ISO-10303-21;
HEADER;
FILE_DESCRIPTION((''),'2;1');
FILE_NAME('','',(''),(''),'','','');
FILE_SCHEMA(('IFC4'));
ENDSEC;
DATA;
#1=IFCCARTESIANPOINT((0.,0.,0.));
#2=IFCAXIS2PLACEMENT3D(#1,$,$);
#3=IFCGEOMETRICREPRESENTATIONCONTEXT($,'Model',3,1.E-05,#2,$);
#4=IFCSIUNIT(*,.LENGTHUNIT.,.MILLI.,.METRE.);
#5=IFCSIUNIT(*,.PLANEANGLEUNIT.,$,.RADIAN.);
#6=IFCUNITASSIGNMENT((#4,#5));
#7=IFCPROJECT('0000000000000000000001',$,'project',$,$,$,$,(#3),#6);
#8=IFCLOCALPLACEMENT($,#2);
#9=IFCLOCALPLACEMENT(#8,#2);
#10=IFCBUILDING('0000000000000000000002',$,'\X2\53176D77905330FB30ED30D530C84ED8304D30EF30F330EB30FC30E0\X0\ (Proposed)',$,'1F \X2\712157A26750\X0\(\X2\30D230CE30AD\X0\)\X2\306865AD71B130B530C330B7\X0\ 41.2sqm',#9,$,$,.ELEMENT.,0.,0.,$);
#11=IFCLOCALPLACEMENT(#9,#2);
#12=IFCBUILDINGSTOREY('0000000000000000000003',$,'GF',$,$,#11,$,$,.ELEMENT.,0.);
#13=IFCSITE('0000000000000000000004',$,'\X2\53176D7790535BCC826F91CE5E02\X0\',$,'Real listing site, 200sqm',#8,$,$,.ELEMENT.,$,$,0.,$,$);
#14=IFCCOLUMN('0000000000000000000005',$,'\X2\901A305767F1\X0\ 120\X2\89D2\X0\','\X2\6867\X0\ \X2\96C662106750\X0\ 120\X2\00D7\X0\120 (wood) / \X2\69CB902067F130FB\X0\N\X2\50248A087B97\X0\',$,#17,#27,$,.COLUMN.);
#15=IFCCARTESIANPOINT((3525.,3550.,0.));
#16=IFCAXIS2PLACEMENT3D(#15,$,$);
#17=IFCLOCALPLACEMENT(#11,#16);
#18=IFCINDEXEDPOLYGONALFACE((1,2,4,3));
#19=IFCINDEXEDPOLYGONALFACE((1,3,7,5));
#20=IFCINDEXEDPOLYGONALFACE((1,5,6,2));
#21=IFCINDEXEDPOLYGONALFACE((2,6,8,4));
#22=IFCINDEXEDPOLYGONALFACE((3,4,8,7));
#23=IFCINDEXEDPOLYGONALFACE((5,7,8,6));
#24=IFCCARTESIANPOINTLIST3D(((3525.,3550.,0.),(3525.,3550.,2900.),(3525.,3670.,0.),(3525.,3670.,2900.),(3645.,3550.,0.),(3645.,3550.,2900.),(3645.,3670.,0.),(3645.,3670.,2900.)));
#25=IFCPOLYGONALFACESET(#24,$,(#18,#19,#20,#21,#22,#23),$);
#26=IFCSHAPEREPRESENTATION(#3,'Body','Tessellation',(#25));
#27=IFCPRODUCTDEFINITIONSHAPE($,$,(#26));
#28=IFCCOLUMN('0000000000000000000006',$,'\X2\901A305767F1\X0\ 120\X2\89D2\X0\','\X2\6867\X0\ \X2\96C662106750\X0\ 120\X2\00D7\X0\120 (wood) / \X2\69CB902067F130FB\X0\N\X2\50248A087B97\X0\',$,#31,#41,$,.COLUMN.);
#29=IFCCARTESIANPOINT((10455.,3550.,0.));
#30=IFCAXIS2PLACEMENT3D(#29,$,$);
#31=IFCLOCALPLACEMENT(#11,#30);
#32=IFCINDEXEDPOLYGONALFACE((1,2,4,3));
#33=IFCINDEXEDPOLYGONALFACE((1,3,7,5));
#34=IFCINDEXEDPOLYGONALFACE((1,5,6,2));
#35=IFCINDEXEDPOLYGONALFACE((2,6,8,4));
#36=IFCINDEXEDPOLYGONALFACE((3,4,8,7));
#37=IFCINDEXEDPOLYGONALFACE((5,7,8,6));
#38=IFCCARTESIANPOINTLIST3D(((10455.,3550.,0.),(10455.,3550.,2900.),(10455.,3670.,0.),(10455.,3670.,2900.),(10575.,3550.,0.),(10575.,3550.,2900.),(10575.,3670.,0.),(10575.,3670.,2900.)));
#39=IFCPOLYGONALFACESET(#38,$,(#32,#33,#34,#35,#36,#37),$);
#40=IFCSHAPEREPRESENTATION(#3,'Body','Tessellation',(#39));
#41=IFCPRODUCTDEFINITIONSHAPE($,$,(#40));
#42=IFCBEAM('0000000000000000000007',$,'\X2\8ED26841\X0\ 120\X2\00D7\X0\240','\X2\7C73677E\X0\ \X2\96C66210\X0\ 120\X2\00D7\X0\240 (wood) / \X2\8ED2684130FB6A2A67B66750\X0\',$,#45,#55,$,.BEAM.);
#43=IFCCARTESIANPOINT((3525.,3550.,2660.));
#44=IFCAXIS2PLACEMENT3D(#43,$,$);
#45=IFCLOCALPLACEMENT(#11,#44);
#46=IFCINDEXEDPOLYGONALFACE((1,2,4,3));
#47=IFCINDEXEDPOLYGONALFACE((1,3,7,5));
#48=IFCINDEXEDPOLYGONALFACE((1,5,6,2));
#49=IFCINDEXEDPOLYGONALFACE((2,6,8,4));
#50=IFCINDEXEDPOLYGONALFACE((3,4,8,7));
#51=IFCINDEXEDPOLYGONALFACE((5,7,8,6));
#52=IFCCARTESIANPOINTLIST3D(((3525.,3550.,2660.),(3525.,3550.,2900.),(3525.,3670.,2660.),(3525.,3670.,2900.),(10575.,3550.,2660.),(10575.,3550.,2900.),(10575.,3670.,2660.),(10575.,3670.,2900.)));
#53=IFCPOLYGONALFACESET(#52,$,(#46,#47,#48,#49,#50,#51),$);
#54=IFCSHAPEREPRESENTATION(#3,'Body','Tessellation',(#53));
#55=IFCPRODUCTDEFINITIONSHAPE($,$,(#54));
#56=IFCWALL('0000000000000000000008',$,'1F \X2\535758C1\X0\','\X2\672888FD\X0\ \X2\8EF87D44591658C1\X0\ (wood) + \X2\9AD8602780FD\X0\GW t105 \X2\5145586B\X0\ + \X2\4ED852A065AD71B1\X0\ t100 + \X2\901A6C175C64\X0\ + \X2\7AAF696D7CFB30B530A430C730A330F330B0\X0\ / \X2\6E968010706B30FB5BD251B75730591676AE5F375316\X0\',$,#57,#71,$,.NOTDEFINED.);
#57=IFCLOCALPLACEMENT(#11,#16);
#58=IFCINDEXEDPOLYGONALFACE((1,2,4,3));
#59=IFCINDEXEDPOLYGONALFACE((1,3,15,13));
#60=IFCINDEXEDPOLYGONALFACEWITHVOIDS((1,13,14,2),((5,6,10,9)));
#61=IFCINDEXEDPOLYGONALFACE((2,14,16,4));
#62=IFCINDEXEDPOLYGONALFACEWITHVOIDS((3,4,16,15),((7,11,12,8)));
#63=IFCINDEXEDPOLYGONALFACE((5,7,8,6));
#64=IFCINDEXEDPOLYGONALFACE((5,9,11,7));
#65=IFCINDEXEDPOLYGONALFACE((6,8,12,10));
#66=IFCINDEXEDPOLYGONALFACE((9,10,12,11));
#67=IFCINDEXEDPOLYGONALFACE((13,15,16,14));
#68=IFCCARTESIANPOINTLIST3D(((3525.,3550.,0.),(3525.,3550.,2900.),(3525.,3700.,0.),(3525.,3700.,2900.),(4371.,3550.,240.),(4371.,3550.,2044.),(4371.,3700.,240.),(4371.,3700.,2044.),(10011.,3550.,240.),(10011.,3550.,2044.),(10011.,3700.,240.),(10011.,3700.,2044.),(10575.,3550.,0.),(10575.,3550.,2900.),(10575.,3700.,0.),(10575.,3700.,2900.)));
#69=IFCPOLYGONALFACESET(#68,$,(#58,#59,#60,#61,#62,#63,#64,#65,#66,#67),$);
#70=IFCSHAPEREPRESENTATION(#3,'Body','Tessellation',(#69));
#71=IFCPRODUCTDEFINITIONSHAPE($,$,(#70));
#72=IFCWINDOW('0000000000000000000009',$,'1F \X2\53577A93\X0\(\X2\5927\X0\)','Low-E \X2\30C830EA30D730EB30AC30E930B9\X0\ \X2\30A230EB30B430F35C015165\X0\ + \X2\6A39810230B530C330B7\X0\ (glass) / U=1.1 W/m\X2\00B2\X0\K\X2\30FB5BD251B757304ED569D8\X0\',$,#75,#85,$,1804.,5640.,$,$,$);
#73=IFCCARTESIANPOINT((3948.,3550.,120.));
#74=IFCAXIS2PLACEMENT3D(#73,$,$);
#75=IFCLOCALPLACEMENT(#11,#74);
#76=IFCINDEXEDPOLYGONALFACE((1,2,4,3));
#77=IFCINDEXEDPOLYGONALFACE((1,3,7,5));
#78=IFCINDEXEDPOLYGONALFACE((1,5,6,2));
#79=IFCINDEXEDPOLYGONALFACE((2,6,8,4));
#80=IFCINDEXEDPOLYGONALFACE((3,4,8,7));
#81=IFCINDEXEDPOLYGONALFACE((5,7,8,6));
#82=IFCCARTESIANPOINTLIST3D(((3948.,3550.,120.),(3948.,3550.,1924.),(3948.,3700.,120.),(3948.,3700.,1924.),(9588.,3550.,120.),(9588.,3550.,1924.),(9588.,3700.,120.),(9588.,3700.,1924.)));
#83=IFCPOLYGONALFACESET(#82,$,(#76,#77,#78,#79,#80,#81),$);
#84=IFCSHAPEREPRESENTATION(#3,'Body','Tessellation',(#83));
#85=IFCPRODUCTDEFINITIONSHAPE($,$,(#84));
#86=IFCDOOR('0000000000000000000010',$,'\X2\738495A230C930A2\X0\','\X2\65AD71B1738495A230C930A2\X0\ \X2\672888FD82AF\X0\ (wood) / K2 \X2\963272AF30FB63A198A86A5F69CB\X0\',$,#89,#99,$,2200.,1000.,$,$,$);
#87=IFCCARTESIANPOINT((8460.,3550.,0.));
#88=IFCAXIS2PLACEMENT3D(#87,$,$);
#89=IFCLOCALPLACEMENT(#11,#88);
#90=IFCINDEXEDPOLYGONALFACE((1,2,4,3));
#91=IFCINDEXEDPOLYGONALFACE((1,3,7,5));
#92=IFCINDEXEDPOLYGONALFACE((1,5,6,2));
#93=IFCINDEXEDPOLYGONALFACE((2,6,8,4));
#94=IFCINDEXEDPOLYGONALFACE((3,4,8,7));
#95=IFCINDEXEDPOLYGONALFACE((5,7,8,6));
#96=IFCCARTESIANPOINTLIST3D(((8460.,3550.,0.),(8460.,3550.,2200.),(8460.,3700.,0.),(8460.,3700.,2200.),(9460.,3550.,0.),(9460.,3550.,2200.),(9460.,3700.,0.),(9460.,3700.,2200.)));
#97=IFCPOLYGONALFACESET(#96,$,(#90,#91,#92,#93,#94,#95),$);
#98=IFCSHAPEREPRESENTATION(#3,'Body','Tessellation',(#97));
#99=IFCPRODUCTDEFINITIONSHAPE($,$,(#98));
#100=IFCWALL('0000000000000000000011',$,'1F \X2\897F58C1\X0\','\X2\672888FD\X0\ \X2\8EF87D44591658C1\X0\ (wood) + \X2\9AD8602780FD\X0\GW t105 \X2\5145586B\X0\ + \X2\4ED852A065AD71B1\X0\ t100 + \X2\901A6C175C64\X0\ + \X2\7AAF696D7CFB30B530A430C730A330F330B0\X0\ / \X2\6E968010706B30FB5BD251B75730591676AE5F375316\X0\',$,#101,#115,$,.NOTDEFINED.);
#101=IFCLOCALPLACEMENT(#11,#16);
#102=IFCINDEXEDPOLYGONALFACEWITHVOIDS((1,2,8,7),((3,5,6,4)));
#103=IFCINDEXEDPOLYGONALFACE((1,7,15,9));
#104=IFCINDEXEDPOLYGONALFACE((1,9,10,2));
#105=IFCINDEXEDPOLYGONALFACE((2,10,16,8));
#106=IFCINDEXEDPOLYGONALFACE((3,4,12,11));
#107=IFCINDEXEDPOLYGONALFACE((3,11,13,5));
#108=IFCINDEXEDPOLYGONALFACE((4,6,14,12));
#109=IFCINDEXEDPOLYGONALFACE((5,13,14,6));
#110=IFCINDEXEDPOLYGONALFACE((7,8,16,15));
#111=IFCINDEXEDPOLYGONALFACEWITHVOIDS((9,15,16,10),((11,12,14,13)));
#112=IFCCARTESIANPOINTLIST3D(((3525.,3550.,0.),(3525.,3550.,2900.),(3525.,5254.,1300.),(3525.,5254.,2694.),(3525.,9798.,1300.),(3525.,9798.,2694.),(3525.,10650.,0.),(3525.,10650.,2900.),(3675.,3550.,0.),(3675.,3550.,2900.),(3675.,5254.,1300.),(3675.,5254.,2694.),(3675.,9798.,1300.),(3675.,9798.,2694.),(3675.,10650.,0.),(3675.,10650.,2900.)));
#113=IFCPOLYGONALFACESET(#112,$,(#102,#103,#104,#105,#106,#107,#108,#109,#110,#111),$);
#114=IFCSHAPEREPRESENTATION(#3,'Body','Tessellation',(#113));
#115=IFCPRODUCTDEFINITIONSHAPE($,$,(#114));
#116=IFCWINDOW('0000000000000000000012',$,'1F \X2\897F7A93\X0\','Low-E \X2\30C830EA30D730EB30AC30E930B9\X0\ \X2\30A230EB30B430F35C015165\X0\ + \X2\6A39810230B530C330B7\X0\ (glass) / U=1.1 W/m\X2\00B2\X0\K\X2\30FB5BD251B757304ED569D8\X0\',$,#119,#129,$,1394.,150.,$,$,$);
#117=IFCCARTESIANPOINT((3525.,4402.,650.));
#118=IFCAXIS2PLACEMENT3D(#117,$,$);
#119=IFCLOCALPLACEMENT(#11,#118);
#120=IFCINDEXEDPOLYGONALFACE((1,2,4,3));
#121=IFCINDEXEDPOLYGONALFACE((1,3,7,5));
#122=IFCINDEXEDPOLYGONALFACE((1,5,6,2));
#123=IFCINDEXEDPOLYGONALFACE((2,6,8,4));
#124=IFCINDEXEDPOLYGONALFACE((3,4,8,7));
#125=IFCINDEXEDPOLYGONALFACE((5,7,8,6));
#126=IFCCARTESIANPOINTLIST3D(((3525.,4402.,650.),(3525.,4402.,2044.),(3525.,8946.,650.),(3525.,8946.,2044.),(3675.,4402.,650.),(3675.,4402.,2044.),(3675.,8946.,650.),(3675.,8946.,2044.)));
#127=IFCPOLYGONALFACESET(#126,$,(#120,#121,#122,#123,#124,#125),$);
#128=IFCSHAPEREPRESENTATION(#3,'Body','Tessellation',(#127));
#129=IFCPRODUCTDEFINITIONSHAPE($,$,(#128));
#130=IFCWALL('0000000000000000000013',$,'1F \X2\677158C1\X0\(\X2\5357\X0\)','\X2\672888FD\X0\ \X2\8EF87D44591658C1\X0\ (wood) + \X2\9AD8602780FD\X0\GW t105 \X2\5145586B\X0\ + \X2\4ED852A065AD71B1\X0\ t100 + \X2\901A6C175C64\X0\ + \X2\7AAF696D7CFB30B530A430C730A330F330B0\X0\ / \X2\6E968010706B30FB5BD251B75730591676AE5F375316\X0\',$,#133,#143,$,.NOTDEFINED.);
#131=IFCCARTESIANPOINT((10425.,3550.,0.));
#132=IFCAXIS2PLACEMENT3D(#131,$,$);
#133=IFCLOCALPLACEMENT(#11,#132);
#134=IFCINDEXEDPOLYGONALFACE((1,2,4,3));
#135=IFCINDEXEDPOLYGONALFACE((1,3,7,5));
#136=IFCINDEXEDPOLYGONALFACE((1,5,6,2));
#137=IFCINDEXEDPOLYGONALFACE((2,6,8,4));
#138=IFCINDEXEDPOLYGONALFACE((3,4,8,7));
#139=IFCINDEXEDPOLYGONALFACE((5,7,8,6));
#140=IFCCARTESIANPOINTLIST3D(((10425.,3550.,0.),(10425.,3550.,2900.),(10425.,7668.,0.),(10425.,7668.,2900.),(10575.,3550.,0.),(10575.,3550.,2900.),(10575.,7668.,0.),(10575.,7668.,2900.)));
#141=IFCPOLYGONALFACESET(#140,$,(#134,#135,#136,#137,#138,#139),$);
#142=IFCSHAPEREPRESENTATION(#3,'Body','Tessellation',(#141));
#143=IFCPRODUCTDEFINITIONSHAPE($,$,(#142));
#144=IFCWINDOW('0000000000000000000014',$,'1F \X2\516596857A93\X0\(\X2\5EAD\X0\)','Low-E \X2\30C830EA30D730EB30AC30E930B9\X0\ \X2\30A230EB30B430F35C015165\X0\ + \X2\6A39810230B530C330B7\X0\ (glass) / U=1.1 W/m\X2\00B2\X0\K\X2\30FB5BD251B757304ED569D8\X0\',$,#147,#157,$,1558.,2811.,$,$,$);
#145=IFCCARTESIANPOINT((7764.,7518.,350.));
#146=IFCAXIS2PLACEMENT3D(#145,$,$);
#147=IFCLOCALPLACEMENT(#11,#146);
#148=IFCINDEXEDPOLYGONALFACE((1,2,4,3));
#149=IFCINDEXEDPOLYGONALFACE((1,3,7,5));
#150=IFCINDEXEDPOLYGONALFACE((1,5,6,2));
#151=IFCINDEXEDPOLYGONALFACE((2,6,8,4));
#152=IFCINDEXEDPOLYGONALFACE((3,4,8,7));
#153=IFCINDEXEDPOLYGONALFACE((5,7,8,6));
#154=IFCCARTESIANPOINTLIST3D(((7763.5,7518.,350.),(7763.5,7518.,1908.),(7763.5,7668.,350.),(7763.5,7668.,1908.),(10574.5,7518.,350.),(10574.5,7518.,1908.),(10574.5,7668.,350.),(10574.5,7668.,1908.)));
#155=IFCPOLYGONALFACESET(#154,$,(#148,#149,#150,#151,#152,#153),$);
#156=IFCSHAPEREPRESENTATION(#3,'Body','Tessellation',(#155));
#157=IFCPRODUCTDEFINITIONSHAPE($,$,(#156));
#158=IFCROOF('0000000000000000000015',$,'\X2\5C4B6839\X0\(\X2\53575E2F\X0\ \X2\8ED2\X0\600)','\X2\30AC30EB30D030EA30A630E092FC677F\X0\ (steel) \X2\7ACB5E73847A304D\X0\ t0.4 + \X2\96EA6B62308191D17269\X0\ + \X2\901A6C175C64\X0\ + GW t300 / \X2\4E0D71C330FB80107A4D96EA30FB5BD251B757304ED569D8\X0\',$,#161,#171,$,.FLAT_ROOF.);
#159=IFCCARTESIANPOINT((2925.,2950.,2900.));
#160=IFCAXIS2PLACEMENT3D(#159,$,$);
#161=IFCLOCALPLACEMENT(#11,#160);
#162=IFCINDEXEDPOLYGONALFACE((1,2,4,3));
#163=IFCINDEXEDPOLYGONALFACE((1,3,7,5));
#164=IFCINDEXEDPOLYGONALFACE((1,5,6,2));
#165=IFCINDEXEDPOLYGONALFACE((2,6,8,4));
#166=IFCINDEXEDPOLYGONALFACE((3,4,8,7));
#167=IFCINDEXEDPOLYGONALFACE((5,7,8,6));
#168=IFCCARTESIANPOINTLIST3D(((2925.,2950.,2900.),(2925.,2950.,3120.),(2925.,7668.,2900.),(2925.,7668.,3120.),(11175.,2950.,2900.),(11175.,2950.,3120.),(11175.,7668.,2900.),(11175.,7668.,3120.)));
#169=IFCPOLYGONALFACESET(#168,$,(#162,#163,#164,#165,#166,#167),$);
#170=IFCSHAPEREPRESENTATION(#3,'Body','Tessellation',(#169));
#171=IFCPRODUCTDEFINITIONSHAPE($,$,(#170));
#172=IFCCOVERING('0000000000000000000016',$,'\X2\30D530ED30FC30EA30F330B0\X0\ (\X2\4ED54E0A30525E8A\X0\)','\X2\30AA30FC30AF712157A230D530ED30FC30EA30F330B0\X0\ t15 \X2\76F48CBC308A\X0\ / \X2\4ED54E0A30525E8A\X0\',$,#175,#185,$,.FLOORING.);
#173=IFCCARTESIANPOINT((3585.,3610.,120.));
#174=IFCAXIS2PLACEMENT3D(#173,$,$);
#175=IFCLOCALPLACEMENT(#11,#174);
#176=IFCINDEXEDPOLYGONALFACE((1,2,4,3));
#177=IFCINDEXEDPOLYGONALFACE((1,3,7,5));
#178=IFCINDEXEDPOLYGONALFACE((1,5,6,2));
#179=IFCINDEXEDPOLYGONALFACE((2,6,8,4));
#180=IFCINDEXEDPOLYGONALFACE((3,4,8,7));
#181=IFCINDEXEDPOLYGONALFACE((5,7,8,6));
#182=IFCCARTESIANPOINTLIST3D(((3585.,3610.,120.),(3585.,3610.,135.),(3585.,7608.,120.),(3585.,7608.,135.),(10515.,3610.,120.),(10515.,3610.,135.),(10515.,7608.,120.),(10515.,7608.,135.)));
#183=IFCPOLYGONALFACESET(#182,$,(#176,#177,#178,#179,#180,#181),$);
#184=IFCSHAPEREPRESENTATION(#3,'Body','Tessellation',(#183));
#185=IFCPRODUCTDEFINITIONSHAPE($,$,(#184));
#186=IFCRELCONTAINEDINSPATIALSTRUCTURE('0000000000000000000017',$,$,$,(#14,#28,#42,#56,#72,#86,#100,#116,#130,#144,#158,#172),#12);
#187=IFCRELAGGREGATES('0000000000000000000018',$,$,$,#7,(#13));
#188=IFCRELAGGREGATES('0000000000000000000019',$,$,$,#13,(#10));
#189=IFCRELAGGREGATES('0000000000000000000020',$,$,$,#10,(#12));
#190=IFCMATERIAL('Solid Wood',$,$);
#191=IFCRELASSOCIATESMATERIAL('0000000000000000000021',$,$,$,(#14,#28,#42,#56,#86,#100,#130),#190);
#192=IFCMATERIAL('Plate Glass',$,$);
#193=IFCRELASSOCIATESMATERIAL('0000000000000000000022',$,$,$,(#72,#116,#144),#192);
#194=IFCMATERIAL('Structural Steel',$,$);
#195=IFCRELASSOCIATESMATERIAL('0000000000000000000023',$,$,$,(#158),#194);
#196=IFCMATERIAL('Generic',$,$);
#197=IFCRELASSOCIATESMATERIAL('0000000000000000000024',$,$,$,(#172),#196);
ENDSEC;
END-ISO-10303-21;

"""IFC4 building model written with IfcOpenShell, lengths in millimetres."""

from ifc_helpers import new_model, si_unit, frame, frame_2d, origin, place, context, project, spatial, rectangle, extrude, material, element, fill, save


model = new_model("IFC4")

# Units and contexts
model_context = context("Model", 3, precision=1e-05, world=origin())
ifc_project = project(units=[si_unit("LENGTHUNIT", "METRE", prefix="MILLI"), si_unit("PLANEANGLEUNIT", "RADIAN")], contexts=[model_context])

# Site, building, storey
site_placement = place(None, origin())
site = spatial("IfcSite", under=ifc_project, at=site_placement, Name="北海道富良野市", ObjectType="Real listing site, 200sqm", CompositionType="ELEMENT", RefElevation=0.0)
building_placement = place(site_placement, origin())
building = spatial("IfcBuilding", under=site, at=building_placement, Name="北海道・ロフト付きワンルーム (Proposed)", ObjectType="1F 無垢材(ヒノキ)と断熱サッシ 41.2sqm", CompositionType="ELEMENT", ElevationOfRefHeight=0.0, ElevationOfTerrain=0.0)
storey_placement = place(building_placement, origin())
storey = spatial("IfcBuildingStorey", under=building, at=storey_placement, Name="GF", CompositionType="ELEMENT", Elevation=0.0)

# Columns
ifc_material_1 = material(Name="Solid Wood")
column_1_placement = place(storey_placement, frame((3525.0, 3550.0, 0.0)))
element("IfcColumn", 1, at=column_1_placement, inside=storey, material=ifc_material_1, Name="通し柱 120角", Description="桧 集成材 120×120 (wood) / 構造柱・N値計算", PredefinedType="COLUMN", context=model_context, shape_type="SweptSolid", body=[
    extrude(rectangle(XDim=120.0, YDim=120.0, at=frame_2d((60.0, 60.0))), frame((3525.0, 3550.0, 0.0)), (0.0, 0.0, 1.0), 2900.0),
])
column_2_placement = place(storey_placement, frame((10455.0, 3550.0, 0.0)))
element("IfcColumn", 2, at=column_2_placement, inside=storey, material=ifc_material_1, Name="通し柱 120角", Description="桧 集成材 120×120 (wood) / 構造柱・N値計算", PredefinedType="COLUMN", context=model_context, shape_type="SweptSolid", body=[
    extrude(rectangle(XDim=120.0, YDim=120.0, at=frame_2d((60.0, 60.0))), frame((10455.0, 3550.0, 0.0)), (0.0, 0.0, 1.0), 2900.0),
])

# Beam
beam_1_placement = place(storey_placement, frame((3525.0, 3550.0, 2660.0)))
element("IfcBeam", 3, at=beam_1_placement, inside=storey, material=ifc_material_1, Name="軒桁 120×240", Description="米松 集成 120×240 (wood) / 軒桁・横架材", PredefinedType="BEAM", context=model_context, shape_type="SweptSolid", body=[
    extrude(rectangle(XDim=7050.0, YDim=120.0, at=frame_2d((3525.0, 60.0))), frame((3525.0, 3550.0, 2660.0)), (0.0, 0.0, 1.0), 240.0),
])

# Wall, openings, window, door
wall_1_placement = place(storey_placement, frame((3525.0, 3550.0, 0.0)))
wall_1 = element("IfcWall", 4, at=wall_1_placement, inside=storey, material=ifc_material_1, Name="1F 南壁", Description="木製 軸組外壁 (wood) + 高性能GW t105 充填 + 付加断熱 t100 + 通気層 + 窯業系サイディング / 準耐火・寒冷地外皮強化", PredefinedType="NOTDEFINED", context=model_context, shape_type="SweptSolid", body=[
    extrude(rectangle(XDim=7050.0, YDim=150.0, at=frame_2d((3525.0, 75.0))), frame((3525.0, 3550.0, 0.0)), (0.0, 0.0, 1.0), 2900.0),
])
opening_1_placement = place(storey_placement, frame((3948.0, 3550.0, 120.0)))
opening_1 = element("IfcOpeningElement", 5, at=opening_1_placement, cuts=wall_1, PredefinedType="NOTDEFINED", context=model_context, shape_type="SweptSolid", body=[
    extrude(rectangle(XDim=5640.0, YDim=150.0, at=frame_2d((2820.0, 75.0))), frame((3948.0, 3550.0, 120.0)), (0.0, 0.0, 1.0), 1804.0),
])
opening_2_placement = place(storey_placement, frame((8460.0, 3550.0, 0.0)))
opening_2 = element("IfcOpeningElement", 6, at=opening_2_placement, cuts=wall_1, PredefinedType="NOTDEFINED", context=model_context, shape_type="SweptSolid", body=[
    extrude(rectangle(XDim=1000.0, YDim=150.0, at=frame_2d((500.0, 75.0))), frame((8460.0, 3550.0, 0.0)), (0.0, 0.0, 1.0), 2200.0),
])
ifc_material_2 = material(Name="Plate Glass")
window_1_placement = place(storey_placement, frame((3948.0, 3550.0, 120.0)))
window_1 = element("IfcWindow", 7, at=window_1_placement, inside=storey, material=ifc_material_2, Name="1F 南窓(大)", Description="Low-E トリプルガラス アルゴン封入 + 樹脂サッシ (glass) / U=1.1 W/m²K・寒冷地仕様", OverallHeight=1804.0, OverallWidth=5640.0, context=model_context, shape_type="SweptSolid", body=[
    extrude(rectangle(XDim=5640.0, YDim=150.0, at=frame_2d((2820.0, 75.0))), frame((3948.0, 3550.0, 120.0)), (0.0, 0.0, 1.0), 1804.0),
])
fill(opening_1, window_1)
door_1_placement = place(storey_placement, frame((8460.0, 3550.0, 0.0)))
door_1 = element("IfcDoor", 8, at=door_1_placement, inside=storey, material=ifc_material_1, Name="玄関ドア", Description="断熱玄関ドア 木製芯 (wood) / K2 防犯・採風機構", OverallHeight=2200.0, OverallWidth=1000.0, context=model_context, shape_type="SweptSolid", body=[
    extrude(rectangle(XDim=1000.0, YDim=150.0, at=frame_2d((500.0, 75.0))), frame((8460.0, 3550.0, 0.0)), (0.0, 0.0, 1.0), 2200.0),
])
fill(opening_2, door_1)

# Walls, openings, windows
wall_2_placement = place(storey_placement, frame((3525.0, 3550.0, 0.0)))
wall_2 = element("IfcWall", 9, at=wall_2_placement, inside=storey, material=ifc_material_1, Name="1F 西壁", Description="木製 軸組外壁 (wood) + 高性能GW t105 充填 + 付加断熱 t100 + 通気層 + 窯業系サイディング / 準耐火・寒冷地外皮強化", PredefinedType="NOTDEFINED", context=model_context, shape_type="SweptSolid", body=[
    extrude(rectangle(XDim=150.0, YDim=7100.0, at=frame_2d((75.0, 3550.0))), frame((3525.0, 3550.0, 0.0)), (0.0, 0.0, 1.0), 2900.0),
])
opening_3_placement = place(storey_placement, frame((3525.0, 4402.0, 650.0)))
opening_3 = element("IfcOpeningElement", 10, at=opening_3_placement, cuts=wall_2, PredefinedType="NOTDEFINED", context=model_context, shape_type="SweptSolid", body=[
    extrude(rectangle(XDim=150.0, YDim=4544.0, at=frame_2d((75.0, 2272.0))), frame((3525.0, 4402.0, 650.0)), (0.0, 0.0, 1.0), 1394.0),
])
window_2_placement = place(storey_placement, frame((3525.0, 4402.0, 650.0)))
window_2 = element("IfcWindow", 11, at=window_2_placement, inside=storey, material=ifc_material_2, Name="1F 西窓", Description="Low-E トリプルガラス アルゴン封入 + 樹脂サッシ (glass) / U=1.1 W/m²K・寒冷地仕様", OverallHeight=1394.0, OverallWidth=150.0, context=model_context, shape_type="SweptSolid", body=[
    extrude(rectangle(XDim=150.0, YDim=4544.0, at=frame_2d((75.0, 2272.0))), frame((3525.0, 4402.0, 650.0)), (0.0, 0.0, 1.0), 1394.0),
])
fill(opening_3, window_2)
wall_3_placement = place(storey_placement, frame((10425.0, 3550.0, 0.0)))
wall_3 = element("IfcWall", 12, at=wall_3_placement, inside=storey, material=ifc_material_1, Name="1F 東壁(南)", Description="木製 軸組外壁 (wood) + 高性能GW t105 充填 + 付加断熱 t100 + 通気層 + 窯業系サイディング / 準耐火・寒冷地外皮強化", PredefinedType="NOTDEFINED", context=model_context, shape_type="SweptSolid", body=[
    extrude(rectangle(XDim=150.0, YDim=4118.0, at=frame_2d((75.0, 2059.0))), frame((10425.0, 3550.0, 0.0)), (0.0, 0.0, 1.0), 2900.0),
])
opening_4_placement = place(storey_placement, frame((7764.0, 7518.0, 350.0)))
opening_4 = element("IfcOpeningElement", 13, at=opening_4_placement, cuts=wall_3, PredefinedType="NOTDEFINED", context=model_context, shape_type="SweptSolid", body=[
    extrude(rectangle(XDim=2811.0, YDim=150.0, at=frame_2d((1405.0, 75.0))), frame((7764.0, 7518.0, 350.0)), (0.0, 0.0, 1.0), 1558.0),
])
window_3_placement = place(storey_placement, frame((7764.0, 7518.0, 350.0)))
window_3 = element("IfcWindow", 14, at=window_3_placement, inside=storey, material=ifc_material_2, Name="1F 入隅窓(庭)", Description="Low-E トリプルガラス アルゴン封入 + 樹脂サッシ (glass) / U=1.1 W/m²K・寒冷地仕様", OverallHeight=1558.0, OverallWidth=2811.0, context=model_context, shape_type="SweptSolid", body=[
    extrude(rectangle(XDim=2811.0, YDim=150.0, at=frame_2d((1405.0, 75.0))), frame((7764.0, 7518.0, 350.0)), (0.0, 0.0, 1.0), 1558.0),
])
fill(opening_4, window_3)

# Roof
ifc_material_3 = material(Name="Structural Steel")
roof_placement = place(storey_placement, frame((2925.0, 2950.0, 2900.0)))
element("IfcRoof", 15, at=roof_placement, inside=storey, material=ifc_material_3, Name="屋根(南帯 軒600)", Description="ガルバリウム鋼板 (steel) 立平葺き t0.4 + 雪止め金物 + 通気層 + GW t300 / 不燃・耐積雪・寒冷地仕様", PredefinedType="FLAT_ROOF", context=model_context, shape_type="SweptSolid", body=[
    extrude(rectangle(XDim=8250.0, YDim=4718.0, at=frame_2d((4125.0, 2359.0))), frame((2925.0, 2950.0, 2900.0)), (0.0, 0.0, 1.0), 220.0),
])

# Covering
ifc_material_4 = material(Name="Generic")
covering_1_placement = place(storey_placement, frame((3585.0, 3610.0, 120.0)))
element("IfcCovering", 16, at=covering_1_placement, inside=storey, material=ifc_material_4, Name="フローリング (仕上げ床)", Description="オーク無垢フローリング t15 直貼り / 仕上げ床", PredefinedType="FLOORING", context=model_context, shape_type="SweptSolid", body=[
    extrude(rectangle(XDim=6930.0, YDim=3998.0, at=frame_2d((3465.0, 1999.0))), frame((3585.0, 3610.0, 120.0)), (0.0, 0.0, 1.0), 15.0),
])

save(model, "model.ifc")
